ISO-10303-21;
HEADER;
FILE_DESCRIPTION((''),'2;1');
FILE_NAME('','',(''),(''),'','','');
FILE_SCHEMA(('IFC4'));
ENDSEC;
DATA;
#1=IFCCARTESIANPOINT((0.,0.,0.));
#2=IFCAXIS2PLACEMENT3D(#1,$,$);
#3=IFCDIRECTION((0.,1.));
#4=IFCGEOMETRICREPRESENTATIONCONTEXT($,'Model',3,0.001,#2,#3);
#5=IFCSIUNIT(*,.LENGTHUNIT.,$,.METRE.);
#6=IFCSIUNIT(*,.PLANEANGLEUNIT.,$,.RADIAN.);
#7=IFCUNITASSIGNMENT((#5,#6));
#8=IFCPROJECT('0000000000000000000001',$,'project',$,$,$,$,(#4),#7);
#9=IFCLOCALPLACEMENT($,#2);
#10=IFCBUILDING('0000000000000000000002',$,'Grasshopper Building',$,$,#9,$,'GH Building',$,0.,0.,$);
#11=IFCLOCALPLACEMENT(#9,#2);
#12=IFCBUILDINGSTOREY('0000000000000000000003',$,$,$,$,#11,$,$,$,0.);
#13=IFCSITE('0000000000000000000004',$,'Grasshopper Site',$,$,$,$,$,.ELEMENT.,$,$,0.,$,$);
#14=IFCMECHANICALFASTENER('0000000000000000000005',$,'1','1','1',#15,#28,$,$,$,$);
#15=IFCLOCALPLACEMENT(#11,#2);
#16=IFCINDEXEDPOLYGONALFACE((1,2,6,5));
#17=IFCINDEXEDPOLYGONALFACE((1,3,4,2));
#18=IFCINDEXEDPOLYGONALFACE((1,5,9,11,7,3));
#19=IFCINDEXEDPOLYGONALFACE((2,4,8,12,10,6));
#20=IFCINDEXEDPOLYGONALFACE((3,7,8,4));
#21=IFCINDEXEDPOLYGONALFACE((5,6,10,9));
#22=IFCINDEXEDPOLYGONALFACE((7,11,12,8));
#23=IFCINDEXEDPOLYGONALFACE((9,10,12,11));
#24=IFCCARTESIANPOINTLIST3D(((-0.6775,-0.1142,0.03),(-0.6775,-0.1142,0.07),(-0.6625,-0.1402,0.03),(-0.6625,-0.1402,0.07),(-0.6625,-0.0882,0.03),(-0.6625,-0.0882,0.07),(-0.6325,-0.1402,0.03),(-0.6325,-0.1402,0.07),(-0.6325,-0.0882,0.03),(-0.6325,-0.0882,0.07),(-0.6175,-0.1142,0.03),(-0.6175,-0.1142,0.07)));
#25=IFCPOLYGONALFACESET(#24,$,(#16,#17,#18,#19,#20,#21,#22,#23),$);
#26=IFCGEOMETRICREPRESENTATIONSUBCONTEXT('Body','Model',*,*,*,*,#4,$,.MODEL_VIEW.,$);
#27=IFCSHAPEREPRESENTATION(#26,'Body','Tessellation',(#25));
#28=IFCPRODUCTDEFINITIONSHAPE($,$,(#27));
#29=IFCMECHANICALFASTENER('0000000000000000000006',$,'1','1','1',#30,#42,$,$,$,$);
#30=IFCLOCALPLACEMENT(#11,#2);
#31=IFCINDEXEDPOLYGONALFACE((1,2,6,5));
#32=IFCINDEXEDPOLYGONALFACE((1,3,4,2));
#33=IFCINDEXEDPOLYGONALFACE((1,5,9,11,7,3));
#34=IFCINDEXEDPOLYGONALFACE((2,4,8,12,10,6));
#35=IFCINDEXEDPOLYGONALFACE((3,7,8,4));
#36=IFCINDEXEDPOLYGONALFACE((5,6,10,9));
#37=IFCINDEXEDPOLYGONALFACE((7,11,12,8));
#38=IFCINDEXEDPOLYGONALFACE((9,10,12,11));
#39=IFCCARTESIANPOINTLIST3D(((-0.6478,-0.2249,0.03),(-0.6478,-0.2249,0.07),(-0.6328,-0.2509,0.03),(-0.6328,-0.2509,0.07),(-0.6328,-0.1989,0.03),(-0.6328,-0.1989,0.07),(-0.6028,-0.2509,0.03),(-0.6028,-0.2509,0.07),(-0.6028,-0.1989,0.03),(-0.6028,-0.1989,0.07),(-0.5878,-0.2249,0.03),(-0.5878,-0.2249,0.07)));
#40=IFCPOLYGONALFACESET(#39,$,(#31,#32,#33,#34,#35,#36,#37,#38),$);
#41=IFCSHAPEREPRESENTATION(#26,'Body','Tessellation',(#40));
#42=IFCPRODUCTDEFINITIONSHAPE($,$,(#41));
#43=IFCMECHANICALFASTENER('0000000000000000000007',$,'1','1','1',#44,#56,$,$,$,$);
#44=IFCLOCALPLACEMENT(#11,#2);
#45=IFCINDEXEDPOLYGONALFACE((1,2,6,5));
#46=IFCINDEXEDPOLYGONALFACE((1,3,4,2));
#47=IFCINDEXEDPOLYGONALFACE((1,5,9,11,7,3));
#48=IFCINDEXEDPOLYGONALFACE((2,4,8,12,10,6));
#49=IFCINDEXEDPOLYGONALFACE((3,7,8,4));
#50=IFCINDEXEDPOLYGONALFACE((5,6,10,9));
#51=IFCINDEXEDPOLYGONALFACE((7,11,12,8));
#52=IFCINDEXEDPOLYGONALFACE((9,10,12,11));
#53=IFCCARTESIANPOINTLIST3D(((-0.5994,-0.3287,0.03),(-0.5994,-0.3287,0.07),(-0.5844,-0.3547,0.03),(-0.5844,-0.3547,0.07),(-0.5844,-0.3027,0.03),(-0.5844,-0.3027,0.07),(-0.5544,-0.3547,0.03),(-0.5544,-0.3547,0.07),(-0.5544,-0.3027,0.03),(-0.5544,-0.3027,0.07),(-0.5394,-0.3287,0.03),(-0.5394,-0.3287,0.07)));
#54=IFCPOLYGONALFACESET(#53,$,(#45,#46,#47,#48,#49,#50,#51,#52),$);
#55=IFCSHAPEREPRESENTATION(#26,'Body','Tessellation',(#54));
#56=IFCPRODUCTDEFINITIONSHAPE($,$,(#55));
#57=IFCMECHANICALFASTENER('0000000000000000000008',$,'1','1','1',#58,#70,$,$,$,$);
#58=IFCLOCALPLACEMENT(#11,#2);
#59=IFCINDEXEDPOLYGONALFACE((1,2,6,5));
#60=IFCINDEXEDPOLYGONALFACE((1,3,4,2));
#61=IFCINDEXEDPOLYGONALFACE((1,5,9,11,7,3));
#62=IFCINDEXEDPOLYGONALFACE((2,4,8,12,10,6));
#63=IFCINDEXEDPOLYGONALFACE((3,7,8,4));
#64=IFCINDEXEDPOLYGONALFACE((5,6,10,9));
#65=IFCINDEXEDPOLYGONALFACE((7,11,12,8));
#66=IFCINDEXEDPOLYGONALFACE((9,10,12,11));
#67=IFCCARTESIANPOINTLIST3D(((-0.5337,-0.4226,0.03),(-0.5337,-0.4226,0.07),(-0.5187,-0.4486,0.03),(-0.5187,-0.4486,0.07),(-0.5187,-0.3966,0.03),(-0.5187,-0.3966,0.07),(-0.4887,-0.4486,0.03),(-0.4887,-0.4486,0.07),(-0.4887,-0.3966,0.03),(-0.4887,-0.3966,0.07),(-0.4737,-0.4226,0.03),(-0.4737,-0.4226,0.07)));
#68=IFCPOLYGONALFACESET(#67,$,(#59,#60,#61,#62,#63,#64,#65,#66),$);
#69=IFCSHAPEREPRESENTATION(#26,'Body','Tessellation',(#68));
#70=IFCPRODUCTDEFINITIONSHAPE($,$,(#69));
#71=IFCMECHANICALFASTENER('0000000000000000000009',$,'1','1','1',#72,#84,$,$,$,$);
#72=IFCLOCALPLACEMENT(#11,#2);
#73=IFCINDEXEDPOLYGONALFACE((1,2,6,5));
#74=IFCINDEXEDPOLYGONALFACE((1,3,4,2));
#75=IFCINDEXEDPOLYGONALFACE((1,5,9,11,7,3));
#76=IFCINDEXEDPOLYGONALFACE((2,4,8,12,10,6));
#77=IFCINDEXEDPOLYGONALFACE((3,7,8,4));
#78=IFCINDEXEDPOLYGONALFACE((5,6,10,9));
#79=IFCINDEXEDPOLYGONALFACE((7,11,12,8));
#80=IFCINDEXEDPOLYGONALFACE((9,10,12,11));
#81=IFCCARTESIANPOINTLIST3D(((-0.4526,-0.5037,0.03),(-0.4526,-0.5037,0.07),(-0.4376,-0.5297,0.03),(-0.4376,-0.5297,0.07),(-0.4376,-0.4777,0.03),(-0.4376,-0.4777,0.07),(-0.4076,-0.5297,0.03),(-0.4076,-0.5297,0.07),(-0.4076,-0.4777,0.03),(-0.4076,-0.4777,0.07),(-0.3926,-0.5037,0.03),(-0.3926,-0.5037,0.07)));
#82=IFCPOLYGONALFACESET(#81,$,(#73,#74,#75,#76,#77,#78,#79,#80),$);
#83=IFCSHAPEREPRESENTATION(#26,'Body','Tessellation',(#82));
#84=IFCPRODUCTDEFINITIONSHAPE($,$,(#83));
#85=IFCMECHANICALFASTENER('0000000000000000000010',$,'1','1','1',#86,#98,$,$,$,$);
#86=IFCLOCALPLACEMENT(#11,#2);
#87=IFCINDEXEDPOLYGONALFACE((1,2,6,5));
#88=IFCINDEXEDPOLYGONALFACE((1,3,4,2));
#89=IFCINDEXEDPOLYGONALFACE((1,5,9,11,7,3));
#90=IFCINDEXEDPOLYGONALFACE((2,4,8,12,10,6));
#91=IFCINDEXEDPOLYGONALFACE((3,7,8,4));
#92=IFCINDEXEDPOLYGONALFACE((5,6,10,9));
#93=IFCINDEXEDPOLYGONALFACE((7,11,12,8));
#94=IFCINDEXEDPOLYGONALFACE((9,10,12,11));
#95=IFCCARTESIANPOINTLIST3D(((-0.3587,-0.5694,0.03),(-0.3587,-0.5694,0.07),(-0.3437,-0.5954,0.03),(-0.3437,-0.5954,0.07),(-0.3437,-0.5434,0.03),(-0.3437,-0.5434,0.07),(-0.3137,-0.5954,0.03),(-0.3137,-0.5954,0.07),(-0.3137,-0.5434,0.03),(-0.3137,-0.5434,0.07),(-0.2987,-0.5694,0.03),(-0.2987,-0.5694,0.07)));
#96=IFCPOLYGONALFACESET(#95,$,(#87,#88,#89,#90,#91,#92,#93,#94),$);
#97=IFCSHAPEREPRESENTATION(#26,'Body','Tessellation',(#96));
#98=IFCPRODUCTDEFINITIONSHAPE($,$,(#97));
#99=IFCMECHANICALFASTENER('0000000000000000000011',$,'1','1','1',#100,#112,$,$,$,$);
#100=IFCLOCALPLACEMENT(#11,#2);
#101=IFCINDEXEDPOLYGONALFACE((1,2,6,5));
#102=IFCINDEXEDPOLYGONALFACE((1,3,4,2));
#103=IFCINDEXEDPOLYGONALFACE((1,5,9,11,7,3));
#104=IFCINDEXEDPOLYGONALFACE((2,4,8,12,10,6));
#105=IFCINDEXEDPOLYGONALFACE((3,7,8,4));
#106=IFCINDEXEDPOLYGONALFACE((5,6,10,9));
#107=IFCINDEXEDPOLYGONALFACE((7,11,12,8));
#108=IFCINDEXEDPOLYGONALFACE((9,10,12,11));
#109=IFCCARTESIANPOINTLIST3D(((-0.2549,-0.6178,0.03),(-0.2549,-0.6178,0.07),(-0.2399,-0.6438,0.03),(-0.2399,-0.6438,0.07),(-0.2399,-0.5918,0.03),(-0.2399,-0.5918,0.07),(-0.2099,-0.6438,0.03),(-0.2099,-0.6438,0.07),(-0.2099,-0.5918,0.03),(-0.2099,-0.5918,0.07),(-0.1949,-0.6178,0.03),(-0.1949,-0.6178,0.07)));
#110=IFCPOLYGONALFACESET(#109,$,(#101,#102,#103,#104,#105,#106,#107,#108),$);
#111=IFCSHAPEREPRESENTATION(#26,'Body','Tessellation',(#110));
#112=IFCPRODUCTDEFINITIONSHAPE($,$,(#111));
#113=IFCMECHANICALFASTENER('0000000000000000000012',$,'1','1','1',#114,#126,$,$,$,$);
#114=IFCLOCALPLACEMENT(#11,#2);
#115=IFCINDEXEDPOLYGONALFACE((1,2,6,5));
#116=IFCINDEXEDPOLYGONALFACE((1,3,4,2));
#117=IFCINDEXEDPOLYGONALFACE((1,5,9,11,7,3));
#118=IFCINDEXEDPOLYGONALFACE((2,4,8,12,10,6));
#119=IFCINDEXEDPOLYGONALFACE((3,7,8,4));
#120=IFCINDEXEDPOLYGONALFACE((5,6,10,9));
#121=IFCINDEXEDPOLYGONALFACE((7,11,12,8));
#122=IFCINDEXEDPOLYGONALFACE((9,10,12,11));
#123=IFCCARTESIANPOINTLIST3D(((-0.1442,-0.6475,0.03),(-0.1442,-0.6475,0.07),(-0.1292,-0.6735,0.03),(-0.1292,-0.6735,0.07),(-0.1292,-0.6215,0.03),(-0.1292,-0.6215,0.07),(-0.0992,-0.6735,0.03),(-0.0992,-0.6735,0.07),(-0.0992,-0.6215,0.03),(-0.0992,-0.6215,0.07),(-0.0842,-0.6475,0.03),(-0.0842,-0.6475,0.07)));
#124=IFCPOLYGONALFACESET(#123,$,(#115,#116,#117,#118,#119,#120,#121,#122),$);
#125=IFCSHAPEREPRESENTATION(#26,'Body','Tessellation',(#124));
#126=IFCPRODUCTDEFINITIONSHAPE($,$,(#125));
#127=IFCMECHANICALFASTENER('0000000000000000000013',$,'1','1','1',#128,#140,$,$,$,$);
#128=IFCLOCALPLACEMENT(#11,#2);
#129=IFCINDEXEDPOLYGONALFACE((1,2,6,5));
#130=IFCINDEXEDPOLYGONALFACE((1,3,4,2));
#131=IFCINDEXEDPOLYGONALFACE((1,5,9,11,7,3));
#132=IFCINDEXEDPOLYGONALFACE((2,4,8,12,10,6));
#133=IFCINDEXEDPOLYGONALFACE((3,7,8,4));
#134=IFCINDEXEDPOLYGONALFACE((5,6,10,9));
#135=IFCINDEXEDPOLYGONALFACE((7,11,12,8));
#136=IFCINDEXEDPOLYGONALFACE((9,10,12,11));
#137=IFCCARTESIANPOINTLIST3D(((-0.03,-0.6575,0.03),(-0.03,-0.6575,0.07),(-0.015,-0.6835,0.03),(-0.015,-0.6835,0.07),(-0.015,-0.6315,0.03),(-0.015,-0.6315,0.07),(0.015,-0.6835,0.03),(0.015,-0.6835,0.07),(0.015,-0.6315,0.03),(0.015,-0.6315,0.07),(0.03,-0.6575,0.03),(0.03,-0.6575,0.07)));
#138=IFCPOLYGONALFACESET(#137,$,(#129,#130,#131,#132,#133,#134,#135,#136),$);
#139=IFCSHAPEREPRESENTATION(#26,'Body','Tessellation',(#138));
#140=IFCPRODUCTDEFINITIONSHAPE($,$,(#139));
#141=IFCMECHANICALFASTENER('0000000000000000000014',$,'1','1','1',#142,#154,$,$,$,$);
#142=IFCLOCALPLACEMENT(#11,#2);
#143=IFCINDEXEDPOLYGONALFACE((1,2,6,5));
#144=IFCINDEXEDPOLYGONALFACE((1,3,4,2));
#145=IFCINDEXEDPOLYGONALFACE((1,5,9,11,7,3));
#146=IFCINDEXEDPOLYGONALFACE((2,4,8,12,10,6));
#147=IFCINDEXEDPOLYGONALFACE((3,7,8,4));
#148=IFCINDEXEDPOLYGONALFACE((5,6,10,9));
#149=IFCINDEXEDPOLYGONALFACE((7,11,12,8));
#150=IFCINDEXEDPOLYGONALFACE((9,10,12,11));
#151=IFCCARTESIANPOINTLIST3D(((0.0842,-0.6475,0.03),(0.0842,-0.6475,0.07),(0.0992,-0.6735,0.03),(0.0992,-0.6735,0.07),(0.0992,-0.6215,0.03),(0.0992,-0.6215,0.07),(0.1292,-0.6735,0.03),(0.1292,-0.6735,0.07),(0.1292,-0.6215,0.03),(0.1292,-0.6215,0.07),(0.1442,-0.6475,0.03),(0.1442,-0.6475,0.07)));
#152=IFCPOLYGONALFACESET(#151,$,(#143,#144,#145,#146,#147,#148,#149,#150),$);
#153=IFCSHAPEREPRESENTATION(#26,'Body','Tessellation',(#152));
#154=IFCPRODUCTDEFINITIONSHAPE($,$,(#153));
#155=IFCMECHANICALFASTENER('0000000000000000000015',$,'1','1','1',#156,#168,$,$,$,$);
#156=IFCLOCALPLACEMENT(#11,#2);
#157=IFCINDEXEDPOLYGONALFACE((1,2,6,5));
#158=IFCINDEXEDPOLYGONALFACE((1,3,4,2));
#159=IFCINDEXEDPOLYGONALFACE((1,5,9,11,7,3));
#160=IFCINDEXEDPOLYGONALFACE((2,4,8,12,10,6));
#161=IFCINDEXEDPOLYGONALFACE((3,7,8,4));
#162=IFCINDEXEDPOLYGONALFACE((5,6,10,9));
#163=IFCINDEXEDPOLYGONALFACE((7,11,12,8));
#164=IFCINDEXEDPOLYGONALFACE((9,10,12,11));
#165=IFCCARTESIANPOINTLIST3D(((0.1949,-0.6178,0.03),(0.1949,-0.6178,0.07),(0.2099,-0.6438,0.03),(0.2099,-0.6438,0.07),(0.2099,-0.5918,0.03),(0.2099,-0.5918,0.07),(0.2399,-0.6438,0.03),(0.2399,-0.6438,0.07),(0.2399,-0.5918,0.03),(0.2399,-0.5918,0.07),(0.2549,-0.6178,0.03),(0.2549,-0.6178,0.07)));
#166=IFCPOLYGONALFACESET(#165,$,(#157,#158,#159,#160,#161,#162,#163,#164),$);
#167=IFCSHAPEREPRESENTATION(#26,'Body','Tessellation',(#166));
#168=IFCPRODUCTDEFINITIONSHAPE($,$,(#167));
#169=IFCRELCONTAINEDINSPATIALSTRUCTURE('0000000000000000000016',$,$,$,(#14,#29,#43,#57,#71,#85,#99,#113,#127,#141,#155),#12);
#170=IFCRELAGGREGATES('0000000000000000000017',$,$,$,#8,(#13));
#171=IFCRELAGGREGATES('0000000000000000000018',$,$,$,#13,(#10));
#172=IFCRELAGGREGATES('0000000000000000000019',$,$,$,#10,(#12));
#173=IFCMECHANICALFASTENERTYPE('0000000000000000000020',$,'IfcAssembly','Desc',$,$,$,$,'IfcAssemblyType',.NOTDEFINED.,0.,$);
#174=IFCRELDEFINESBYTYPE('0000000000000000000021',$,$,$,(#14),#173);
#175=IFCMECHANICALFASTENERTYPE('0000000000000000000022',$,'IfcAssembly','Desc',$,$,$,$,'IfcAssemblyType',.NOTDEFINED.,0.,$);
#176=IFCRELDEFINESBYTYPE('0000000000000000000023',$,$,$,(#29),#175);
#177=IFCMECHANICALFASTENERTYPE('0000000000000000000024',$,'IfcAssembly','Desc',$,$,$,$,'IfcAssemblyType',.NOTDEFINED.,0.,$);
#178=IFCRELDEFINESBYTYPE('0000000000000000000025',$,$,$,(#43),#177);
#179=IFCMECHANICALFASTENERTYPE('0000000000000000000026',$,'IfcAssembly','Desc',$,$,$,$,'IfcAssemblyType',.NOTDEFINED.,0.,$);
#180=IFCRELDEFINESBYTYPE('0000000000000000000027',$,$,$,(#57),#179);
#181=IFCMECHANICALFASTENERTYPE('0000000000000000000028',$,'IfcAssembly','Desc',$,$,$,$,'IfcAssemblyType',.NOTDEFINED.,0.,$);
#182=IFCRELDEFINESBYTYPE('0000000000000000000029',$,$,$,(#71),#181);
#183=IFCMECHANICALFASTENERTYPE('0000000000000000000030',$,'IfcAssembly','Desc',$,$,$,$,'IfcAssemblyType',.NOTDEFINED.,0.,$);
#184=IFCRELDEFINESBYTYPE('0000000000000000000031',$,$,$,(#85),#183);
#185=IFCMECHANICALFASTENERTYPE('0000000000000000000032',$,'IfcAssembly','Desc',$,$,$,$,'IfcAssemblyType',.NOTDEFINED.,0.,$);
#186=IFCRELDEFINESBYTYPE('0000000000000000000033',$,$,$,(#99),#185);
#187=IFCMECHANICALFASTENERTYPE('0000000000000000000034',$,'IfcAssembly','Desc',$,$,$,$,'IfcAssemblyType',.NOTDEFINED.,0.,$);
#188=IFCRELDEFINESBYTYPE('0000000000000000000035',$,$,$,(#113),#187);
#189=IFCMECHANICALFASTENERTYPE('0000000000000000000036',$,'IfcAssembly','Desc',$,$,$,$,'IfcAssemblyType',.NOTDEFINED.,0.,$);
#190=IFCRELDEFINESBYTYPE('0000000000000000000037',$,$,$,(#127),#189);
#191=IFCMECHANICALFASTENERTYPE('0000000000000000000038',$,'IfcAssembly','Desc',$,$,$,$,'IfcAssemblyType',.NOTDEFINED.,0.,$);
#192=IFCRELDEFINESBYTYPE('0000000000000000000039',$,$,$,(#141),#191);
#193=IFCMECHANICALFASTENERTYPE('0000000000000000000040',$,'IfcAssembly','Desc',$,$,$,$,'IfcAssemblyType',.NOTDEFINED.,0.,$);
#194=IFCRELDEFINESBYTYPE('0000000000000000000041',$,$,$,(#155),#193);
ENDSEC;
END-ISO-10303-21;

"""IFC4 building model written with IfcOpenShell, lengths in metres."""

from ifc_helpers import new_model, si_unit, direction, frame, origin, place, context, subcontext, project, spatial, indexed_curve, outline, extrude, source, transform, mapped, type_object, type_shapes, element, save


model = new_model("IFC4")

# Units and contexts
model_context = context("Model", 3, precision=0.001, world=origin(), true_north=direction((0.0, 1.0)))
body_context = subcontext(model_context, "Body", "Model", "MODEL_VIEW")
ifc_project = project(units=[si_unit("LENGTHUNIT", "METRE"), si_unit("PLANEANGLEUNIT", "RADIAN")], contexts=[model_context])

# Site, building, storey
site = spatial("IfcSite", under=ifc_project, Name="Grasshopper Site", CompositionType="ELEMENT", RefElevation=0.0)
building_placement = place(None, origin())
building = spatial("IfcBuilding", under=site, at=building_placement, Name="Grasshopper Building", LongName="GH Building", ElevationOfRefHeight=0.0, ElevationOfTerrain=0.0)
storey_placement = place(building_placement, origin())
storey = spatial("IfcBuildingStorey", under=building, at=storey_placement, Elevation=0.0)

# Mechanical fasteners
mechanical_fastener_type_1 = type_object("IfcMechanicalFastenerType", Name="IfcAssembly", Description="Desc", ElementType="IfcAssemblyType", NominalDiameter=0.0)
shared_shape_1 = source(origin(), body_context, "Body", "SweptSolid", [
    extrude(outline(indexed_curve([(0.03, 0.0), (0.015, 0.026), (-0.015, 0.026), (-0.03, 0.0), (-0.015, -0.026), (0.015, -0.026), (0.03, 0.0)])), frame((-0.6475, -0.1142, 0.03)), (0.0, 0.0, 1.0), 0.04),
])
type_shapes(mechanical_fastener_type_1, [shared_shape_1])
mechanical_fastener_1_placement = place(storey_placement, origin())
element("IfcMechanicalFastener", 1, at=mechanical_fastener_1_placement, inside=storey, type_object=mechanical_fastener_type_1, Name="1", Description="1", ObjectType="1", context=body_context, shape_type="MappedRepresentation", body=[
    mapped(shared_shape_1, transform((0.0, 0.0, 0.0), scale=1.0)),
])
mechanical_fastener_type_2 = type_object("IfcMechanicalFastenerType", Name="IfcAssembly", Description="Desc", ElementType="IfcAssemblyType", NominalDiameter=0.0)
shared_shape_2 = source(origin(), body_context, "Body", "SweptSolid", [
    extrude(outline(indexed_curve([(0.03, 0.0), (0.015, 0.026), (-0.015, 0.026), (-0.03, 0.0), (-0.015, -0.026), (0.015, -0.026), (0.03, 0.0)])), frame((-0.6178, -0.2249, 0.03)), (0.0, 0.0, 1.0), 0.04),
])
type_shapes(mechanical_fastener_type_2, [shared_shape_2])
mechanical_fastener_2_placement = place(storey_placement, origin())
element("IfcMechanicalFastener", 2, at=mechanical_fastener_2_placement, inside=storey, type_object=mechanical_fastener_type_2, Name="1", Description="1", ObjectType="1", context=body_context, shape_type="MappedRepresentation", body=[
    mapped(shared_shape_2, transform((0.0, 0.0, 0.0), scale=1.0)),
])
mechanical_fastener_type_3 = type_object("IfcMechanicalFastenerType", Name="IfcAssembly", Description="Desc", ElementType="IfcAssemblyType", NominalDiameter=0.0)
shared_shape_3 = source(origin(), body_context, "Body", "SweptSolid", [
    extrude(outline(indexed_curve([(0.03, 0.0), (0.015, 0.026), (-0.015, 0.026), (-0.03, 0.0), (-0.015, -0.026), (0.015, -0.026), (0.03, 0.0)])), frame((-0.5694, -0.3287, 0.03)), (0.0, 0.0, 1.0), 0.04),
])
type_shapes(mechanical_fastener_type_3, [shared_shape_3])
mechanical_fastener_3_placement = place(storey_placement, origin())
element("IfcMechanicalFastener", 3, at=mechanical_fastener_3_placement, inside=storey, type_object=mechanical_fastener_type_3, Name="1", Description="1", ObjectType="1", context=body_context, shape_type="MappedRepresentation", body=[
    mapped(shared_shape_3, transform((0.0, 0.0, 0.0), scale=1.0)),
])
mechanical_fastener_type_4 = type_object("IfcMechanicalFastenerType", Name="IfcAssembly", Description="Desc", ElementType="IfcAssemblyType", NominalDiameter=0.0)
shared_shape_4 = source(origin(), body_context, "Body", "SweptSolid", [
    extrude(outline(indexed_curve([(0.03, 0.0), (0.015, 0.026), (-0.015, 0.026), (-0.03, 0.0), (-0.015, -0.026), (0.015, -0.026), (0.03, 0.0)])), frame((-0.5037, -0.4226, 0.03)), (0.0, 0.0, 1.0), 0.04),
])
type_shapes(mechanical_fastener_type_4, [shared_shape_4])
mechanical_fastener_4_placement = place(storey_placement, origin())
element("IfcMechanicalFastener", 4, at=mechanical_fastener_4_placement, inside=storey, type_object=mechanical_fastener_type_4, Name="1", Description="1", ObjectType="1", context=body_context, shape_type="MappedRepresentation", body=[
    mapped(shared_shape_4, transform((0.0, 0.0, 0.0), scale=1.0)),
])
mechanical_fastener_type_5 = type_object("IfcMechanicalFastenerType", Name="IfcAssembly", Description="Desc", ElementType="IfcAssemblyType", NominalDiameter=0.0)
shared_shape_5 = source(origin(), body_context, "Body", "SweptSolid", [
    extrude(outline(indexed_curve([(0.03, 0.0), (0.015, 0.026), (-0.015, 0.026), (-0.03, 0.0), (-0.015, -0.026), (0.015, -0.026), (0.03, 0.0)])), frame((-0.4226, -0.5037, 0.03)), (0.0, 0.0, 1.0), 0.04),
])
type_shapes(mechanical_fastener_type_5, [shared_shape_5])
mechanical_fastener_5_placement = place(storey_placement, origin())
element("IfcMechanicalFastener", 5, at=mechanical_fastener_5_placement, inside=storey, type_object=mechanical_fastener_type_5, Name="1", Description="1", ObjectType="1", context=body_context, shape_type="MappedRepresentation", body=[
    mapped(shared_shape_5, transform((0.0, 0.0, 0.0), scale=1.0)),
])
mechanical_fastener_type_6 = type_object("IfcMechanicalFastenerType", Name="IfcAssembly", Description="Desc", ElementType="IfcAssemblyType", NominalDiameter=0.0)
shared_shape_6 = source(origin(), body_context, "Body", "SweptSolid", [
    extrude(outline(indexed_curve([(0.03, 0.0), (0.015, 0.026), (-0.015, 0.026), (-0.03, 0.0), (-0.015, -0.026), (0.015, -0.026), (0.03, 0.0)])), frame((-0.3287, -0.5694, 0.03)), (0.0, 0.0, 1.0), 0.04),
])
type_shapes(mechanical_fastener_type_6, [shared_shape_6])
mechanical_fastener_6_placement = place(storey_placement, origin())
element("IfcMechanicalFastener", 6, at=mechanical_fastener_6_placement, inside=storey, type_object=mechanical_fastener_type_6, Name="1", Description="1", ObjectType="1", context=body_context, shape_type="MappedRepresentation", body=[
    mapped(shared_shape_6, transform((0.0, 0.0, 0.0), scale=1.0)),
])
mechanical_fastener_type_7 = type_object("IfcMechanicalFastenerType", Name="IfcAssembly", Description="Desc", ElementType="IfcAssemblyType", NominalDiameter=0.0)
shared_shape_7 = source(origin(), body_context, "Body", "SweptSolid", [
    extrude(outline(indexed_curve([(0.03, 0.0), (0.015, 0.026), (-0.015, 0.026), (-0.03, 0.0), (-0.015, -0.026), (0.015, -0.026), (0.03, 0.0)])), frame((-0.2249, -0.6178, 0.03)), (0.0, 0.0, 1.0), 0.04),
])
type_shapes(mechanical_fastener_type_7, [shared_shape_7])
mechanical_fastener_7_placement = place(storey_placement, origin())
element("IfcMechanicalFastener", 7, at=mechanical_fastener_7_placement, inside=storey, type_object=mechanical_fastener_type_7, Name="1", Description="1", ObjectType="1", context=body_context, shape_type="MappedRepresentation", body=[
    mapped(shared_shape_7, transform((0.0, 0.0, 0.0), scale=1.0)),
])
mechanical_fastener_type_8 = type_object("IfcMechanicalFastenerType", Name="IfcAssembly", Description="Desc", ElementType="IfcAssemblyType", NominalDiameter=0.0)
shared_shape_8 = source(origin(), body_context, "Body", "SweptSolid", [
    extrude(outline(indexed_curve([(0.03, 0.0), (0.015, 0.026), (-0.015, 0.026), (-0.03, 0.0), (-0.015, -0.026), (0.015, -0.026), (0.03, 0.0)])), frame((-0.1142, -0.6475, 0.03)), (0.0, 0.0, 1.0), 0.04),
])
type_shapes(mechanical_fastener_type_8, [shared_shape_8])
mechanical_fastener_8_placement = place(storey_placement, origin())
element("IfcMechanicalFastener", 8, at=mechanical_fastener_8_placement, inside=storey, type_object=mechanical_fastener_type_8, Name="1", Description="1", ObjectType="1", context=body_context, shape_type="MappedRepresentation", body=[
    mapped(shared_shape_8, transform((0.0, 0.0, 0.0), scale=1.0)),
])
mechanical_fastener_type_9 = type_object("IfcMechanicalFastenerType", Name="IfcAssembly", Description="Desc", ElementType="IfcAssemblyType", NominalDiameter=0.0)
shared_shape_9 = source(origin(), body_context, "Body", "SweptSolid", [
    extrude(outline(indexed_curve([(0.03, 0.0), (0.015, 0.026), (-0.015, 0.026), (-0.03, 0.0), (-0.015, -0.026), (0.015, -0.026), (0.03, 0.0)])), frame((0.0, -0.6575, 0.03)), (0.0, 0.0, 1.0), 0.04),
])
type_shapes(mechanical_fastener_type_9, [shared_shape_9])
mechanical_fastener_9_placement = place(storey_placement, origin())
element("IfcMechanicalFastener", 9, at=mechanical_fastener_9_placement, inside=storey, type_object=mechanical_fastener_type_9, Name="1", Description="1", ObjectType="1", context=body_context, shape_type="MappedRepresentation", body=[
    mapped(shared_shape_9, transform((0.0, 0.0, 0.0), scale=1.0)),
])
mechanical_fastener_type_10 = type_object("IfcMechanicalFastenerType", Name="IfcAssembly", Description="Desc", ElementType="IfcAssemblyType", NominalDiameter=0.0)
shared_shape_10 = source(origin(), body_context, "Body", "SweptSolid", [
    extrude(outline(indexed_curve([(0.03, 0.0), (0.015, 0.026), (-0.015, 0.026), (-0.03, 0.0), (-0.015, -0.026), (0.015, -0.026), (0.03, 0.0)])), frame((0.1142, -0.6475, 0.03)), (0.0, 0.0, 1.0), 0.04),
])
type_shapes(mechanical_fastener_type_10, [shared_shape_10])
mechanical_fastener_10_placement = place(storey_placement, origin())
element("IfcMechanicalFastener", 10, at=mechanical_fastener_10_placement, inside=storey, type_object=mechanical_fastener_type_10, Name="1", Description="1", ObjectType="1", context=body_context, shape_type="MappedRepresentation", body=[
    mapped(shared_shape_10, transform((0.0, 0.0, 0.0), scale=1.0)),
])
mechanical_fastener_type_11 = type_object("IfcMechanicalFastenerType", Name="IfcAssembly", Description="Desc", ElementType="IfcAssemblyType", NominalDiameter=0.0)
shared_shape_11 = source(origin(), body_context, "Body", "SweptSolid", [
    extrude(outline(indexed_curve([(0.03, 0.0), (0.015, 0.026), (-0.015, 0.026), (-0.03, 0.0), (-0.015, -0.026), (0.015, -0.026), (0.03, 0.0)])), frame((0.2249, -0.6178, 0.03)), (0.0, 0.0, 1.0), 0.04),
])
type_shapes(mechanical_fastener_type_11, [shared_shape_11])
mechanical_fastener_11_placement = place(storey_placement, origin())
element("IfcMechanicalFastener", 11, at=mechanical_fastener_11_placement, inside=storey, type_object=mechanical_fastener_type_11, Name="1", Description="1", ObjectType="1", context=body_context, shape_type="MappedRepresentation", body=[
    mapped(shared_shape_11, transform((0.0, 0.0, 0.0), scale=1.0)),
])

save(model, "model.ifc")
